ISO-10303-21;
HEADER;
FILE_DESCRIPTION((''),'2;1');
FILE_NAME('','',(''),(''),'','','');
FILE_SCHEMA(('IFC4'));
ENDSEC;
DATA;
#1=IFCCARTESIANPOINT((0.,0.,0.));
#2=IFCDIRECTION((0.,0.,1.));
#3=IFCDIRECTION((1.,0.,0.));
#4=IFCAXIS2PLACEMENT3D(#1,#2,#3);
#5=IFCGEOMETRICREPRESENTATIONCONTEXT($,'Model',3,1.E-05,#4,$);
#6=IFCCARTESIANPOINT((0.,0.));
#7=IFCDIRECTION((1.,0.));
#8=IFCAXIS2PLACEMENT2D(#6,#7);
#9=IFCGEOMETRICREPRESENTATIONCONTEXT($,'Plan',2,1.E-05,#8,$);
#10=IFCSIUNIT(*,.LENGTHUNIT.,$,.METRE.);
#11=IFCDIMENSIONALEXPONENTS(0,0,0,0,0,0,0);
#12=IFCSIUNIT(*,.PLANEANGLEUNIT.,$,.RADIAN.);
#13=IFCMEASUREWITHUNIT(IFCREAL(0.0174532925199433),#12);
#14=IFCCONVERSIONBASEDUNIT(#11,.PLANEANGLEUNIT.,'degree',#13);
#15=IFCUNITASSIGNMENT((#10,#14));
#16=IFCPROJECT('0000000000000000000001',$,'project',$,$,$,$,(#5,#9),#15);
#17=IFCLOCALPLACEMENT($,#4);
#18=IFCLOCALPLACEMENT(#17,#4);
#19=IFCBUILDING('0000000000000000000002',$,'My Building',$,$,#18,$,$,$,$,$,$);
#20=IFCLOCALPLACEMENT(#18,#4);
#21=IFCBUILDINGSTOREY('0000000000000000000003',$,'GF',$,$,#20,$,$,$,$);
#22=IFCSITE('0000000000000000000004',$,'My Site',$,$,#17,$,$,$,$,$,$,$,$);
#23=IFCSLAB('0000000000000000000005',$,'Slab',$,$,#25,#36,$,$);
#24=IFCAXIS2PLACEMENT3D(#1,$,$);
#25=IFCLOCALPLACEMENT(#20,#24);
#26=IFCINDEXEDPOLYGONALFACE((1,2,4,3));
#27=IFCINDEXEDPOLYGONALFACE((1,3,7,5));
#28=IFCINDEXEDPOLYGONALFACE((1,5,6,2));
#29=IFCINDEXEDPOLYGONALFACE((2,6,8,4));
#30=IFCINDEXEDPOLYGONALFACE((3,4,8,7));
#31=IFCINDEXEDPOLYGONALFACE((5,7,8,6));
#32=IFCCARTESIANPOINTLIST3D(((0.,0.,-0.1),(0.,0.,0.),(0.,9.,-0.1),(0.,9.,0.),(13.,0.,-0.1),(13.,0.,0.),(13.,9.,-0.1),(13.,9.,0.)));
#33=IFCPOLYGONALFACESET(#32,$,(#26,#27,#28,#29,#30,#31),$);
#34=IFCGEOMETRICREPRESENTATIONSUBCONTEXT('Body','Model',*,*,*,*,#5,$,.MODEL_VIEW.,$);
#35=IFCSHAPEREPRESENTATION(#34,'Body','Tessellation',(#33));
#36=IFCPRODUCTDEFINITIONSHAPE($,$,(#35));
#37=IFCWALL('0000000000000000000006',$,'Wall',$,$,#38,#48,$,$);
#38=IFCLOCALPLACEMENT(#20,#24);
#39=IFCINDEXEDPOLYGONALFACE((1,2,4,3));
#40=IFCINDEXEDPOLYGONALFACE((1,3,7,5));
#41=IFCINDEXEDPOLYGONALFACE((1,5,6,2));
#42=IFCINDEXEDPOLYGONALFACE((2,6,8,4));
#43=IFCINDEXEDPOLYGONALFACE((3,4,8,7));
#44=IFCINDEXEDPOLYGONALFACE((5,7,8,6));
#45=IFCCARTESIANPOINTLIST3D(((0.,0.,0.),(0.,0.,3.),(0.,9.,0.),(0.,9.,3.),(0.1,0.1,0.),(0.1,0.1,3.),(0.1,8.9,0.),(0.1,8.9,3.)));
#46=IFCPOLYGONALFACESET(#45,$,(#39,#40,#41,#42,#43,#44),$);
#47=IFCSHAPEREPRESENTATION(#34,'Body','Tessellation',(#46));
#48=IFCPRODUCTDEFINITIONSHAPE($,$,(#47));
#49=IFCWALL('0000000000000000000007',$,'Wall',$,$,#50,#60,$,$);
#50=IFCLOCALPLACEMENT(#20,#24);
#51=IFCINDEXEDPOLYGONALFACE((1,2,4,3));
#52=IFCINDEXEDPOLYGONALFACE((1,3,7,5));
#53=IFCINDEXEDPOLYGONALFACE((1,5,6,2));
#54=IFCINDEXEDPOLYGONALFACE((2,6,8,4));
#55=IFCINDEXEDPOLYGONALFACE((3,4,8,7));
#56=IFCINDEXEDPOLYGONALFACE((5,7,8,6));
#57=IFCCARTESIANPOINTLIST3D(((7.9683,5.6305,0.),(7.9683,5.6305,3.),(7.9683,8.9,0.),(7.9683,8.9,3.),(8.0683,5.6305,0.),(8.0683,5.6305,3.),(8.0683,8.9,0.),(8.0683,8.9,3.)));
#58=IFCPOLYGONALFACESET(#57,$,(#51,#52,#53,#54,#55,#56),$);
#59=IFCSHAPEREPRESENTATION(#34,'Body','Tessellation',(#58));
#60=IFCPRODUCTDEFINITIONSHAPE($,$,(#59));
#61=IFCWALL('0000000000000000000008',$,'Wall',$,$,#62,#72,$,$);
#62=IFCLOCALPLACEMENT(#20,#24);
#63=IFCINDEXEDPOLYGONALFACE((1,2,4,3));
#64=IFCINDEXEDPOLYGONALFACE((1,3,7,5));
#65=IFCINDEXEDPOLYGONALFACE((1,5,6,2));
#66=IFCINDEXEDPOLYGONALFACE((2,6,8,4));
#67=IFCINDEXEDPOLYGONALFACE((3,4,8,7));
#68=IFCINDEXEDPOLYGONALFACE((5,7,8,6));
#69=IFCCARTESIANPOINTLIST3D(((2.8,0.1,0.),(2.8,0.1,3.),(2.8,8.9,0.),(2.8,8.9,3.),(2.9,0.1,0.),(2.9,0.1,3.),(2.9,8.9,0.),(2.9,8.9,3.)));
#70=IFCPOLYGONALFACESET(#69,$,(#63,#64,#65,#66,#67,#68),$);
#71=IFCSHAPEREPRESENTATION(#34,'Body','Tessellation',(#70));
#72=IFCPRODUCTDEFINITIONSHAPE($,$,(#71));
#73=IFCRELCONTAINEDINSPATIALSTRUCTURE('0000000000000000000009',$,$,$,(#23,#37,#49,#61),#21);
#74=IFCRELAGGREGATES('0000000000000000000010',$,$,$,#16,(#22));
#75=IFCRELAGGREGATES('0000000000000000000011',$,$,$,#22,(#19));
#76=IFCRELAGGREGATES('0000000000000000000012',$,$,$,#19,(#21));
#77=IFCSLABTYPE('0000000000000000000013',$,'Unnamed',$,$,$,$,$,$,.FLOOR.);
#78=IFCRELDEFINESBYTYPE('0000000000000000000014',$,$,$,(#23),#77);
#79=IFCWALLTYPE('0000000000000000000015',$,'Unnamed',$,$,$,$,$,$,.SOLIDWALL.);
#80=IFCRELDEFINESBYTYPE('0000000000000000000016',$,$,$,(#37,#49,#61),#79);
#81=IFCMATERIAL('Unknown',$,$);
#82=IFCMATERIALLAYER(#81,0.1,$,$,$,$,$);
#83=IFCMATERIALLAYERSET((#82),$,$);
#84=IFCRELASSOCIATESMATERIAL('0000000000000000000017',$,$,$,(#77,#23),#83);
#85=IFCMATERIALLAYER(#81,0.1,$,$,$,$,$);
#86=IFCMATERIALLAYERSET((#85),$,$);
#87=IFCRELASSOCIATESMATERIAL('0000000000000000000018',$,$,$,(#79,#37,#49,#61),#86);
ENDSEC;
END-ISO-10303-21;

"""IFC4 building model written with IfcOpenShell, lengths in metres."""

from ifc_helpers import new_model, entity, si_unit, converted_unit, frame, origin_with_axes, origin_2d_with_axis, place, context, subcontext, project, spatial, line, indexed_curve, outline, extrude, material, layer, layer_set, layer_usage, type_object, element, save


model = new_model("IFC4")

# Units and contexts
model_context = context("Model", 3, precision=1e-05, world=origin_with_axes())
plan_context = context("Plan", 2, precision=1e-05, world=origin_2d_with_axis())
body_context_1 = subcontext(model_context, "Body", "Model", "MODEL_VIEW")
ifc_project = project(units=[si_unit("LENGTHUNIT", "METRE"), converted_unit("PLANEANGLEUNIT", "degree", entity("IfcReal", 0.0174532925199433), si_unit("PLANEANGLEUNIT", "RADIAN"), dimensions=[0, 0, 0, 0, 0, 0, 0])], contexts=[model_context, plan_context])

# Site, building, storey
site_placement = place(None, origin_with_axes())
site = spatial("IfcSite", under=ifc_project, at=site_placement, Name="My Site")
building_placement = place(site_placement, origin_with_axes())
building = spatial("IfcBuilding", under=site, at=building_placement, Name="My Building")
storey_placement = place(building_placement, origin_with_axes())
storey = spatial("IfcBuildingStorey", under=building, at=storey_placement, Name="GF")

# Slab
ifc_material = material(Name="Unknown")
ifc_layer_1 = layer(ifc_material, 0.1)
ifc_layer_set_1 = layer_set([ifc_layer_1])
ifc_layer_usage_1 = layer_usage(ifc_layer_set_1, "AXIS3", "POSITIVE", -0.1)
slab_type = type_object("IfcSlabType", Name="Unnamed", PredefinedType="FLOOR", material=ifc_layer_set_1)
slab_placement = place(storey_placement, frame((0.0, 9.0, 0.0), z_axis=(0.0, 0.0, 1.0), x_axis=(1.0, 0.0, 0.0)))
element("IfcSlab", 1, at=slab_placement, inside=storey, type_object=slab_type, material=ifc_layer_usage_1, Name="Slab", context=body_context_1, shape_type="SweptSolid", body=[
    extrude(outline(indexed_curve([(0.0, -9.0), (13.0, -9.0), (13.0, 0.0), (0.0, 0.0), (0.0, -9.0)])), frame((0.0, 0.0, -0.1), z_axis=(0.0, 0.0, 1.0), x_axis=(1.0, 0.0, 0.0)), (0.0, 0.0, 1.0), 0.1),
])

# Shared definitions
ifc_layer_2 = layer(ifc_material, 0.1)
ifc_layer_set_2 = layer_set([ifc_layer_2])
wall_type = type_object("IfcWallType", Name="Unnamed", PredefinedType="SOLIDWALL", material=ifc_layer_set_2)

# Wall
ifc_layer_usage_2 = layer_usage(ifc_layer_set_2, "AXIS2", "POSITIVE", 0.0)
wall_1_placement = place(storey_placement, frame((0.0, 9.0, 0.0), z_axis=(0.0, 0.0, 1.0), x_axis=(0.0, -1.0, 0.0)))
element("IfcWall", 2, at=wall_1_placement, inside=storey, type_object=wall_type, material=ifc_layer_usage_2, Name="Wall", context=body_context_1, shape_type="SweptSolid", body=[
    extrude(outline(indexed_curve([(0.0, 0.0), (0.1, 0.1), (8.9, 0.1), (9.0, 0.0)], segments=[line(1, 2, 3, 4, 1)])), origin_with_axes(), (0.0, 0.0, 1.0), 3.0),
])

# Walls
ifc_layer_usage_3 = layer_usage(ifc_layer_set_2, "AXIS2", "POSITIVE", 0.0)
wall_2_placement = place(storey_placement, frame((8.0683, 5.6305, 0.0), z_axis=(0.0, 0.0, 1.0), x_axis=(0.0, 1.0, 0.0)))
element("IfcWall", 3, at=wall_2_placement, inside=storey, type_object=wall_type, material=ifc_layer_usage_3, Name="Wall", context=body_context_1, shape_type="SweptSolid", body=[
    extrude(outline(indexed_curve([(0.0, 0.0), (0.0, 0.1), (3.2695, 0.1), (3.2695, 0.0)], segments=[line(1, 2, 3, 4, 1)])), origin_with_axes(), (0.0, 0.0, 1.0), 3.0),
])
ifc_layer_usage_4 = layer_usage(ifc_layer_set_2, "AXIS2", "POSITIVE", 0.0)
wall_3_placement = place(storey_placement, frame((2.8, 9.0, 0.0), z_axis=(0.0, 0.0, 1.0), x_axis=(0.0, -1.0, 0.0)))
element("IfcWall", 4, at=wall_3_placement, inside=storey, type_object=wall_type, material=ifc_layer_usage_4, Name="Wall", context=body_context_1, shape_type="SweptSolid", body=[
    extrude(outline(indexed_curve([(0.1, 0.0), (0.1, 0.1), (8.9, 0.1), (8.9, 0.0)], segments=[line(1, 2, 3, 4, 1)])), origin_with_axes(), (0.0, 0.0, 1.0), 3.0),
])

save(model, "model.ifc")
